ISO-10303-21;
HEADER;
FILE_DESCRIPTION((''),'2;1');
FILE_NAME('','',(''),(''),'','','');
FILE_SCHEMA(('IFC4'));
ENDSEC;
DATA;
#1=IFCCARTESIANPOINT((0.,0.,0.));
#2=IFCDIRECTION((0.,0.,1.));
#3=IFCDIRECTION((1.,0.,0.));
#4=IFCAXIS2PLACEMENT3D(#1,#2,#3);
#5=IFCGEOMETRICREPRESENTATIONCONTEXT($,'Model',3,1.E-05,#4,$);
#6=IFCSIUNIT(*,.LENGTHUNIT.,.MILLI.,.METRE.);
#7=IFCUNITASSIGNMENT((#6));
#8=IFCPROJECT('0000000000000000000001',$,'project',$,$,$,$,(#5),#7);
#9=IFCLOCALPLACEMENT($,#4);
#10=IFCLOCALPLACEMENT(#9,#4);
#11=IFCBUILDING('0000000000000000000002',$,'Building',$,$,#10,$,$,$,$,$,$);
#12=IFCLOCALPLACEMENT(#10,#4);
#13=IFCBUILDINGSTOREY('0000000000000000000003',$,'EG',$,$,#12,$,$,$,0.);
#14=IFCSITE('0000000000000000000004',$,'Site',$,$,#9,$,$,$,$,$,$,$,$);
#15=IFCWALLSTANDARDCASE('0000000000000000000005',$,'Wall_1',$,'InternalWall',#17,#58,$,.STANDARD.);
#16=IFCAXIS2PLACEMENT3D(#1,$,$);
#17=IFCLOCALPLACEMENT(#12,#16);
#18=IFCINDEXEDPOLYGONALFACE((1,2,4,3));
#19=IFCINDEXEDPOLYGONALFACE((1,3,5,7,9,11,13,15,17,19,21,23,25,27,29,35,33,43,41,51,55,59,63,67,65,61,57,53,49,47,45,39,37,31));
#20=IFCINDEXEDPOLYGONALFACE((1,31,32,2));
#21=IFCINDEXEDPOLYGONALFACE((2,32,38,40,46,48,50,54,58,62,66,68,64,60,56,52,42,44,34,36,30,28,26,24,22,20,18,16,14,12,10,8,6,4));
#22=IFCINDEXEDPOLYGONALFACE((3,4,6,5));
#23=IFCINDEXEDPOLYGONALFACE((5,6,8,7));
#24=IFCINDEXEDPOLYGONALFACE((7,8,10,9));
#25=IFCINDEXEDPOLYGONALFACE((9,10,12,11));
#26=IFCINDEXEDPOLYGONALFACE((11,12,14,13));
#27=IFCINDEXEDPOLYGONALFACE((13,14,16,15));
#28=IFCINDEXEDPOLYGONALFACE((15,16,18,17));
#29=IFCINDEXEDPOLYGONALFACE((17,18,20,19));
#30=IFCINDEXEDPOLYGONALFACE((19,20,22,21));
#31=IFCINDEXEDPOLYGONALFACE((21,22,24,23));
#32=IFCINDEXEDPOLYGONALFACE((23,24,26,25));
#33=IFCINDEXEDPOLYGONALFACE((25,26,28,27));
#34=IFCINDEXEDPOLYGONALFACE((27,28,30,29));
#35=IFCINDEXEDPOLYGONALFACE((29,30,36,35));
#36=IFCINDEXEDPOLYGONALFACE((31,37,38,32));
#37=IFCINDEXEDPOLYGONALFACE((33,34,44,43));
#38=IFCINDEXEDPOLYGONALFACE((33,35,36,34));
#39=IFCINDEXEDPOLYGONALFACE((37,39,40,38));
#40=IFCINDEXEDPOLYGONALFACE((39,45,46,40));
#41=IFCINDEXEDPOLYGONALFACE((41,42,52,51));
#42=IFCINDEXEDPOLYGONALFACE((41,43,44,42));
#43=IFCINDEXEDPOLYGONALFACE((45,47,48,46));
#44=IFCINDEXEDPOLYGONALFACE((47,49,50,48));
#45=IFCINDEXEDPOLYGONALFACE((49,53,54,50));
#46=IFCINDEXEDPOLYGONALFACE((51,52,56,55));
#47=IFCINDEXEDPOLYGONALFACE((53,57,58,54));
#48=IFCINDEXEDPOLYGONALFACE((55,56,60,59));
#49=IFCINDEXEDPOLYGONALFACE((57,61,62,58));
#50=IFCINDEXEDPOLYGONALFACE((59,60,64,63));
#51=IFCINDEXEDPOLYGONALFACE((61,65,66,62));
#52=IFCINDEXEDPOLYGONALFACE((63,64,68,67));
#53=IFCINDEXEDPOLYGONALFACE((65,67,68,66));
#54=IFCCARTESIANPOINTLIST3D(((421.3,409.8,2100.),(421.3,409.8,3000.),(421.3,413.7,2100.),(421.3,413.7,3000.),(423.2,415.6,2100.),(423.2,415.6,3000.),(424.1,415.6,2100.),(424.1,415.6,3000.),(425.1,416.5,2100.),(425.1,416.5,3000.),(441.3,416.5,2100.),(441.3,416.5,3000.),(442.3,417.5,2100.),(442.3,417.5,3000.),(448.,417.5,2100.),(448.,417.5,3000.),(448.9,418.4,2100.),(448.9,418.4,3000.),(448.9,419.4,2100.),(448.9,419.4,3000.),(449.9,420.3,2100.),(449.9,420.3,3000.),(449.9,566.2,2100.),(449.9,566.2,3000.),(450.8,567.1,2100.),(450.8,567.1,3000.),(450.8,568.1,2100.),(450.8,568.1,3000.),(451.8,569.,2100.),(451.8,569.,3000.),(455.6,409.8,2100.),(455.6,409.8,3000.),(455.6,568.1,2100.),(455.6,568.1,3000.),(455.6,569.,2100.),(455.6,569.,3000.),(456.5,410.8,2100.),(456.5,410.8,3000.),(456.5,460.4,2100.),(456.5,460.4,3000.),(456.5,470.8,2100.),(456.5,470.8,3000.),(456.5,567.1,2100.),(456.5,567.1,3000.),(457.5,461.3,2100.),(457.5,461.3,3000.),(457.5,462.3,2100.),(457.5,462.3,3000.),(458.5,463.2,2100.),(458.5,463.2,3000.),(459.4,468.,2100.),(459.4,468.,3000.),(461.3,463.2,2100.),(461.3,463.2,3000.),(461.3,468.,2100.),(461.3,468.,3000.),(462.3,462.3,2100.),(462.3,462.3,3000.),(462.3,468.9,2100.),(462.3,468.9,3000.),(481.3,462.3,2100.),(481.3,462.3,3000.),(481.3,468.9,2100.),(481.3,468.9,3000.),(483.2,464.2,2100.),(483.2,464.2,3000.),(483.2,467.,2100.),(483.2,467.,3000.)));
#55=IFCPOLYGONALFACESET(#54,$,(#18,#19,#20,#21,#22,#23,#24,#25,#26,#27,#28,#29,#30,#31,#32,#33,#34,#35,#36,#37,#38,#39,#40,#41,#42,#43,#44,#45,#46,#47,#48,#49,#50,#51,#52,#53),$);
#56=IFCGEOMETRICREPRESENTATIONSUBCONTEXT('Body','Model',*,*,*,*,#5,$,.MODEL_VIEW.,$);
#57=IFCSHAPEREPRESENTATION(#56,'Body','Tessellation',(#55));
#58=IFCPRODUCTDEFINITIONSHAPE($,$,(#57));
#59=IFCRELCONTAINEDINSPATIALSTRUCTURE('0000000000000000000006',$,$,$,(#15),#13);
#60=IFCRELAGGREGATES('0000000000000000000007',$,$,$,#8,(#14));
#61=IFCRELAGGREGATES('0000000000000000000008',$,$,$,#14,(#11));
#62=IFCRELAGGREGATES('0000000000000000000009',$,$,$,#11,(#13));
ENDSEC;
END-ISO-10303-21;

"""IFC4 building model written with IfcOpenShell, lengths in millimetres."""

from ifc_helpers import new_model, si_unit, frame, origin_with_axes, place, context, subcontext, project, spatial, polyline, rectangle, outline, extrude, element, save


model = new_model("IFC4")

# Units and contexts
model_context = context("Model", 3, precision=1e-05, world=origin_with_axes())
body_context = subcontext(model_context, "Body", "Model", "MODEL_VIEW")
ifc_project = project(units=[si_unit("LENGTHUNIT", "METRE", prefix="MILLI")], contexts=[model_context])

# Site, building, storey
site_placement = place(None, origin_with_axes())
site = spatial("IfcSite", under=ifc_project, at=site_placement, Name="Site")
building_placement = place(site_placement, origin_with_axes())
building = spatial("IfcBuilding", under=site, at=building_placement, Name="Building")
storey_placement = place(building_placement, origin_with_axes())
storey = spatial("IfcBuildingStorey", under=building, at=storey_placement, Name="EG", Elevation=0.0)

# Wall, openings
wall_1_placement = place(storey_placement, origin_with_axes())
wall_1 = element("IfcWallStandardCase", 1, at=wall_1_placement, inside=storey, Name="Wall_1", ObjectType="InternalWall", PredefinedType="STANDARD", context=body_context, shape_type="SweptSolid", body=[
    extrude(outline(polyline([(421.3, 409.8, 0.0), (421.3, 413.7, 0.0), (423.2, 415.6, 0.0), (424.1, 415.6, 0.0), (425.1, 416.5, 0.0), (441.3, 416.5, 0.0), (442.3, 417.5, 0.0), (448.0, 417.5, 0.0), (448.9, 418.4, 0.0), (448.9, 419.4, 0.0), (449.9, 420.3, 0.0), (449.9, 566.2, 0.0), (450.8, 567.1, 0.0), (450.8, 568.1, 0.0), (451.8, 569.0, 0.0), (455.6, 569.0, 0.0), (455.6, 568.1, 0.0), (456.5, 567.1, 0.0), (456.5, 470.8, 0.0), (459.4, 468.0, 0.0), (461.3, 468.0, 0.0), (462.3, 468.9, 0.0), (481.3, 468.9, 0.0), (483.2, 467.0, 0.0), (483.2, 464.2, 0.0), (481.3, 462.3, 0.0), (462.3, 462.3, 0.0), (461.3, 463.2, 0.0), (458.5, 463.2, 0.0), (457.5, 462.3, 0.0), (457.5, 461.3, 0.0), (456.5, 460.4, 0.0), (456.5, 410.8, 0.0), (455.6, 409.8, 0.0), (421.3, 409.8, 0.0)])), origin_with_axes(), (0.0, 0.0, 1.0), 3000.0),
])
opening_1_placement = place(wall_1_placement, origin_with_axes())
element("IfcOpeningElement", 2, at=opening_1_placement, inside=storey, cuts=wall_1, context=body_context, shape_type="SweptSolid", body=[
    extrude(rectangle(XDim=450.0, YDim=51.6), frame((461.6, 488.7, 0.0), z_axis=(0.0, 0.0, 1.0), x_axis=(-0.184288, -0.982872, 0.0)), (0.0, 0.0, 1.0), 2100.0),
])
opening_2_placement = place(wall_1_placement, origin_with_axes())
element("IfcOpeningElement", 3, at=opening_2_placement, inside=storey, cuts=wall_1, context=body_context, shape_type="SweptSolid", body=[
    extrude(rectangle(XDim=450.0, YDim=51.6), frame((448.6, 419.4, 0.0), z_axis=(0.0, 0.0, 1.0), x_axis=(-0.184288, -0.982872, 0.0)), (0.0, 0.0, 1.0), 2100.0),
])

save(model, "model.ifc")
